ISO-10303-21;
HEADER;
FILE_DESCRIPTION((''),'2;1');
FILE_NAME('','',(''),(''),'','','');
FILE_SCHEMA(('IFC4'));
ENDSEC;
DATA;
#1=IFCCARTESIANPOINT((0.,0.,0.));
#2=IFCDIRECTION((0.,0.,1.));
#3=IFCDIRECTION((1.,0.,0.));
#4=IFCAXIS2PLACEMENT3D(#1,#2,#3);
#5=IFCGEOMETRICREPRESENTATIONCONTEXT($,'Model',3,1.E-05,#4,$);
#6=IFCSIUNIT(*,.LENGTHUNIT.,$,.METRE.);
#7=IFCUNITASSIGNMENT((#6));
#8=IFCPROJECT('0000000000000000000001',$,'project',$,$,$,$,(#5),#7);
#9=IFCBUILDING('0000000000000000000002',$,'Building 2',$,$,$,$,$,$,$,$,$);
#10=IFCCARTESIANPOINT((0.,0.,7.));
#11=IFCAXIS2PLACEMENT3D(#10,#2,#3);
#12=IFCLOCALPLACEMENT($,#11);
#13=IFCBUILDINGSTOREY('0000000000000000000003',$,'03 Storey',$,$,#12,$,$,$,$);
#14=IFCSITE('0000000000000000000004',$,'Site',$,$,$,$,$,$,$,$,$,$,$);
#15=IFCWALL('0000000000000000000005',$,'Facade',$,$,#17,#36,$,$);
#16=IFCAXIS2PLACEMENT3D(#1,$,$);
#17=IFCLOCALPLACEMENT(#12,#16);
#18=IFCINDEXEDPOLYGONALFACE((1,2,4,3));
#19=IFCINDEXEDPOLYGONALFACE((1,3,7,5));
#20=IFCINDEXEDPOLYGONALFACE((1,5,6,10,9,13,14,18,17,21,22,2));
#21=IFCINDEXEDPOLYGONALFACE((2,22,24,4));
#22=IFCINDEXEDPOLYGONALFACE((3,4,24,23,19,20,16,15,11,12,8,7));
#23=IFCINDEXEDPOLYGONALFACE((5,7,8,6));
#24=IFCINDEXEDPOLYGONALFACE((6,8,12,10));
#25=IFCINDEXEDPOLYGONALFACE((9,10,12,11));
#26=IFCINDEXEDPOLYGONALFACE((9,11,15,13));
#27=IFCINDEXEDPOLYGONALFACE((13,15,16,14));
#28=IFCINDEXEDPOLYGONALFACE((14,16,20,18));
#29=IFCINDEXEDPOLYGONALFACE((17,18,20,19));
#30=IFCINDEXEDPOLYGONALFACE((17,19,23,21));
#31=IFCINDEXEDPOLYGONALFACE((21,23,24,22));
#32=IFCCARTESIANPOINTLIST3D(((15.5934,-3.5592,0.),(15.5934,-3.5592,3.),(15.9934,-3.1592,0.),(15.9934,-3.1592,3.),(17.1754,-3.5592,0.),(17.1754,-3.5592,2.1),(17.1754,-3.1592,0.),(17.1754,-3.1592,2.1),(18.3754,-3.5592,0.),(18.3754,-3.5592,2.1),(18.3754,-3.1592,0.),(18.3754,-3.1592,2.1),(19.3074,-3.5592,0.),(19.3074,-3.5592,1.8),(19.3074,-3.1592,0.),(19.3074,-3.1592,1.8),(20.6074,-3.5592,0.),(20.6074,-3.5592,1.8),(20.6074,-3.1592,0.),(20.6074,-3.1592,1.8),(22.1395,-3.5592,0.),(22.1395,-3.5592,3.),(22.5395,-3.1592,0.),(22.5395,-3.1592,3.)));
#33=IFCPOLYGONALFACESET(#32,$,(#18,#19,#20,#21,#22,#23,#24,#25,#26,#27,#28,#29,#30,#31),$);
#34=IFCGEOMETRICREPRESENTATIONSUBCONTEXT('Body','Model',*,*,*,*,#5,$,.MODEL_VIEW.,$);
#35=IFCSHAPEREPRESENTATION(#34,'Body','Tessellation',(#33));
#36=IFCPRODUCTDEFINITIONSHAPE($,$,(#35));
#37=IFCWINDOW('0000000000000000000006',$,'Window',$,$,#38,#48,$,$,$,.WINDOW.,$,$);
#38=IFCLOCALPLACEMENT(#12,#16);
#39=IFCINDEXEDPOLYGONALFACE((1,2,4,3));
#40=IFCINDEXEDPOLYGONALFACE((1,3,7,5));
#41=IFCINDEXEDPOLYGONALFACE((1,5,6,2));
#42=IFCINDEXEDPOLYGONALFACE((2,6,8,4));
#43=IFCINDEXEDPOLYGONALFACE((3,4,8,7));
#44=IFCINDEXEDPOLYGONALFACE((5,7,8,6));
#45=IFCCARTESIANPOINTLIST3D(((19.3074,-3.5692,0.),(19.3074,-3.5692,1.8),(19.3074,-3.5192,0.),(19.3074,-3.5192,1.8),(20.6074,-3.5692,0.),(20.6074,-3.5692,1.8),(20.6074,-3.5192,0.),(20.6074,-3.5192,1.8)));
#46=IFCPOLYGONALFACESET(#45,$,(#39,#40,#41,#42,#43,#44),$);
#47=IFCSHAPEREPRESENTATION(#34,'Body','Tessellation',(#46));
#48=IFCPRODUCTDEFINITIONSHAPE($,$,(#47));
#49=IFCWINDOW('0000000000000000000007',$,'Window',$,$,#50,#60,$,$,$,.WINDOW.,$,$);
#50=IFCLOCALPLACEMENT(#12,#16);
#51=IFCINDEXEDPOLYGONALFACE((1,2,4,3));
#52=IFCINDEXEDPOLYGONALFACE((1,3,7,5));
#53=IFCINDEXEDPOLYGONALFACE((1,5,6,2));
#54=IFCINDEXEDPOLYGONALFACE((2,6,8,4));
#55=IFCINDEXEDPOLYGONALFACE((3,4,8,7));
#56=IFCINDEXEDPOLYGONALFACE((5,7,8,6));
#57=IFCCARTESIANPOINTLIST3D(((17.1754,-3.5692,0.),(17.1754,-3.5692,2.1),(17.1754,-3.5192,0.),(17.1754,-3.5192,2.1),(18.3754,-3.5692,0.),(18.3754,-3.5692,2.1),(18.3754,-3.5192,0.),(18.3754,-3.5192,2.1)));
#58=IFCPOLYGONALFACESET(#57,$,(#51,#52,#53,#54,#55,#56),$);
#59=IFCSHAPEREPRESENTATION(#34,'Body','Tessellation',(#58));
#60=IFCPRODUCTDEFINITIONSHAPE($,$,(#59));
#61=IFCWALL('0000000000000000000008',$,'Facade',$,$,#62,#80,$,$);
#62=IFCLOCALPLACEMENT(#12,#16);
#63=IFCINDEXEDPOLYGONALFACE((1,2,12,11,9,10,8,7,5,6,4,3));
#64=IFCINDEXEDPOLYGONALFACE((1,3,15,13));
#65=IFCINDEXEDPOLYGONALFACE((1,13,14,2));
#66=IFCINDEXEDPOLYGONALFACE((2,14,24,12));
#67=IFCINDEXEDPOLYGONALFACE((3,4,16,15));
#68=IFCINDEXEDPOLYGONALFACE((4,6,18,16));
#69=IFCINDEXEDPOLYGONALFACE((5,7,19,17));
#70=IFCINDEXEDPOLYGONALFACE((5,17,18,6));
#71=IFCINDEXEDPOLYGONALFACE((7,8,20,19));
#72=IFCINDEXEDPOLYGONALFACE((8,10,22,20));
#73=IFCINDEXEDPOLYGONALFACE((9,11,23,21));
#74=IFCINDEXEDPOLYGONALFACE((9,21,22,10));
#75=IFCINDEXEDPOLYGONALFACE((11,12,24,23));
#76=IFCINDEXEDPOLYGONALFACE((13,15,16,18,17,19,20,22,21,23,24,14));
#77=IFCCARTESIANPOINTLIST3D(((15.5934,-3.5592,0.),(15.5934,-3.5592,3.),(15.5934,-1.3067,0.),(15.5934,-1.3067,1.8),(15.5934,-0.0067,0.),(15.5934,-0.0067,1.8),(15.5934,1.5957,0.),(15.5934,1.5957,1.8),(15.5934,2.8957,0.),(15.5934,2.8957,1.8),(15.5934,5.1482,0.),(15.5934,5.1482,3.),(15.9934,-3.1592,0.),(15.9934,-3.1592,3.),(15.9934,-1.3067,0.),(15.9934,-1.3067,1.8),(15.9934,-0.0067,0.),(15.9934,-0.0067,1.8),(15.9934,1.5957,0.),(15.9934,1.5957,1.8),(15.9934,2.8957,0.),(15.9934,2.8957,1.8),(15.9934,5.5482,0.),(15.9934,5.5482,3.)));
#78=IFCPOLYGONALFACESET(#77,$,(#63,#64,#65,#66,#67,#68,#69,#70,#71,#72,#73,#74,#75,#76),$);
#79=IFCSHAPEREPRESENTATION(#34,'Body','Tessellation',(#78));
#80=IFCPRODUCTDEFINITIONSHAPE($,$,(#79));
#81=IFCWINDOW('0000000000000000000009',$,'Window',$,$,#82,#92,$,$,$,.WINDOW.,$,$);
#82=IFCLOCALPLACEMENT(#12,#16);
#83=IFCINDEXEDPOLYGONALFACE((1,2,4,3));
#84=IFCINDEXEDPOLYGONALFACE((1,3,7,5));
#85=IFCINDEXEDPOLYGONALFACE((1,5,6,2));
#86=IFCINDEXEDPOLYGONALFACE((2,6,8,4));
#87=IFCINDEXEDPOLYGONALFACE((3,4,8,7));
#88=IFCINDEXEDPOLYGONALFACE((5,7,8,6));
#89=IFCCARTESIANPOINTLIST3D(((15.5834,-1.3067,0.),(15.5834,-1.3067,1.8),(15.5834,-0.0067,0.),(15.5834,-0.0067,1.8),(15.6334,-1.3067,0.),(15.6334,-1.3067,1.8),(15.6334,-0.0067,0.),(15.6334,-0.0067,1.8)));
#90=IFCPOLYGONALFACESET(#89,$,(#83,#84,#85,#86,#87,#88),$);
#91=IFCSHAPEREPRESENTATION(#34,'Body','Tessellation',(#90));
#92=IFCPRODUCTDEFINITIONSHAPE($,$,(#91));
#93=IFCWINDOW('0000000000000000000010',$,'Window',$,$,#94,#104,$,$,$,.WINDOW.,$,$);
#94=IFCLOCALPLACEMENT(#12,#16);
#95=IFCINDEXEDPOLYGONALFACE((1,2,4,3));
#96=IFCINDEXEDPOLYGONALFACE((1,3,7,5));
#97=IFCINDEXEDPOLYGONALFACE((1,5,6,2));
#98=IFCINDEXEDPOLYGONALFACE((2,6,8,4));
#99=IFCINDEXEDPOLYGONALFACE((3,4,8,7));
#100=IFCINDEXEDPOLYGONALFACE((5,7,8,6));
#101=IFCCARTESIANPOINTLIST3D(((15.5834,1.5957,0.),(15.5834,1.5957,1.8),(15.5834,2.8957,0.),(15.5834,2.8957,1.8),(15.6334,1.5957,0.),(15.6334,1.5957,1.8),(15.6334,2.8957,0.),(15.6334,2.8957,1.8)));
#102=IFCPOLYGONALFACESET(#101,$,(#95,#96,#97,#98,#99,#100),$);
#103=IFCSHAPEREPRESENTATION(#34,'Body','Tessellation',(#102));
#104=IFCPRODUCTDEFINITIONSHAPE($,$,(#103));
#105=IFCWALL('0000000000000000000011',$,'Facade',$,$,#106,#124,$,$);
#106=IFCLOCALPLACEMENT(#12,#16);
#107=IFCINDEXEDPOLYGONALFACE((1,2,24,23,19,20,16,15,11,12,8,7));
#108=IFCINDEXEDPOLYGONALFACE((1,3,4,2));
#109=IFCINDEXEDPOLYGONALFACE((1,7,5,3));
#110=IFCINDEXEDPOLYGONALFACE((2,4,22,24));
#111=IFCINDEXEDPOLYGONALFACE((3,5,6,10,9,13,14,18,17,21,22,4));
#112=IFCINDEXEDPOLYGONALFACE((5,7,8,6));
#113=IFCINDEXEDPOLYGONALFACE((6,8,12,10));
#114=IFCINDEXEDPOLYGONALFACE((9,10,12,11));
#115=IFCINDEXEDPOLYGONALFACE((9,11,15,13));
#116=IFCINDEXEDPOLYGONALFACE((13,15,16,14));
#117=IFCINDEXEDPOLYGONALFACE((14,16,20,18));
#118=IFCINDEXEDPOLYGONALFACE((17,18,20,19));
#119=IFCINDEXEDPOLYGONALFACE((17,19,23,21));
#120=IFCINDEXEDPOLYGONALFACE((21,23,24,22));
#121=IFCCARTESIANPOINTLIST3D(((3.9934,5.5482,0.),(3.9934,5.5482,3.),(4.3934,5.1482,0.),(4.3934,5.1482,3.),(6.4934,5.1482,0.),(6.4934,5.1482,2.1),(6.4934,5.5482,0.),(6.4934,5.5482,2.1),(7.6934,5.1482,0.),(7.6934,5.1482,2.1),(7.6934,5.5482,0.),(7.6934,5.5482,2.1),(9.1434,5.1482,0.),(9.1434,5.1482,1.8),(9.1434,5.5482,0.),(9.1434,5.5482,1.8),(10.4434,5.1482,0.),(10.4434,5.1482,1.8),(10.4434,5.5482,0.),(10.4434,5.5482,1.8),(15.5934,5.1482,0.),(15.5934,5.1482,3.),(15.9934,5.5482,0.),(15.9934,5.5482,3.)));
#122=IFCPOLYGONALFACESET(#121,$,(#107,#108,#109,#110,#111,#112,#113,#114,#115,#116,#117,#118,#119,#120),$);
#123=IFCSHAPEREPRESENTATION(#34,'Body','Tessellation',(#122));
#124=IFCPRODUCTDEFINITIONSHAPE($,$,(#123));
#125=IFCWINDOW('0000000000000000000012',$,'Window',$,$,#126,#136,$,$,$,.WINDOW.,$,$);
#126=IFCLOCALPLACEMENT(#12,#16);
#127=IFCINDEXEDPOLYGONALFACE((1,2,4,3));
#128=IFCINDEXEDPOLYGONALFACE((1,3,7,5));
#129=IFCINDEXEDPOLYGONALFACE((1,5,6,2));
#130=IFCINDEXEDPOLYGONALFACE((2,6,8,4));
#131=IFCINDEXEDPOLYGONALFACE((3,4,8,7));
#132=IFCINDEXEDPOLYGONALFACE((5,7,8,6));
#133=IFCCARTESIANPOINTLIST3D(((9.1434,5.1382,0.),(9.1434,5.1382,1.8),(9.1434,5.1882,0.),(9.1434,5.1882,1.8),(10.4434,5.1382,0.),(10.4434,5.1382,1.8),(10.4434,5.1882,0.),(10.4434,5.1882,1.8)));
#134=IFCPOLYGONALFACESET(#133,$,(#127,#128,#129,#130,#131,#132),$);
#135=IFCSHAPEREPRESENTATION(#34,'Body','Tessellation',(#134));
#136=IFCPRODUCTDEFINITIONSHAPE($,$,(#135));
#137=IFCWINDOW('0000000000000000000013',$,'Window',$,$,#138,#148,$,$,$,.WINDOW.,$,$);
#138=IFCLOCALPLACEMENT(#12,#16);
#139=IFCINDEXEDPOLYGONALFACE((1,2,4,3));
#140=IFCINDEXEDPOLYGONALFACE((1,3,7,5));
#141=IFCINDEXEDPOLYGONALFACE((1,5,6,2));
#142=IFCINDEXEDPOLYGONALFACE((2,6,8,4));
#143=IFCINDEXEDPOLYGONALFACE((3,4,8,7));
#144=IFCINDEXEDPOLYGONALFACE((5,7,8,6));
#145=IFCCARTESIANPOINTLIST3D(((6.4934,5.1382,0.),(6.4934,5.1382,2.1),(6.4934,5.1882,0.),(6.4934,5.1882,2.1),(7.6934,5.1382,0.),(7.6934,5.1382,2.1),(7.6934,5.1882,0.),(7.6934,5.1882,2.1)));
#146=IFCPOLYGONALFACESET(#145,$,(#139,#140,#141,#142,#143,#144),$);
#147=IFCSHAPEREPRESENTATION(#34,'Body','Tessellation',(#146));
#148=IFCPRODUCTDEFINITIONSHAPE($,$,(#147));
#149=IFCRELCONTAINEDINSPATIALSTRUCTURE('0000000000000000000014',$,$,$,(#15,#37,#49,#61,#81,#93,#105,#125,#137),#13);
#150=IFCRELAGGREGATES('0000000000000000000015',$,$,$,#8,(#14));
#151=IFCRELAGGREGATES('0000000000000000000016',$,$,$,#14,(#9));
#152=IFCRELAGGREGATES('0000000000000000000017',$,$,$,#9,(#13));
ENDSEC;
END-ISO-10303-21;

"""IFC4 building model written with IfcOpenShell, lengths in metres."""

from ifc_helpers import new_model, si_unit, frame, origin_with_axes, place, context, subcontext, project, spatial, line, indexed_curve, outline, extrude, element, fill, save


model = new_model("IFC4")

# Units and contexts
model_context = context("Model", 3, precision=1e-05, world=origin_with_axes())
body_context = subcontext(model_context, "Body", "Model", "MODEL_VIEW")
ifc_project = project(units=[si_unit("LENGTHUNIT", "METRE")], contexts=[model_context])

# Site, building, storey
site = spatial("IfcSite", under=ifc_project, Name="Site")
building = spatial("IfcBuilding", under=site, Name="Building 2")
storey_placement = place(None, frame((0.0, 0.0, 7.0), z_axis=(0.0, 0.0, 1.0), x_axis=(1.0, 0.0, 0.0)))
storey = spatial("IfcBuildingStorey", under=building, at=storey_placement, Name="03 Storey")

# Walls, openings, windows
wall_1_placement = place(storey_placement, origin_with_axes())
wall_1 = element("IfcWall", 1, at=wall_1_placement, inside=storey, Name="Facade", context=body_context, shape_type="SweptSolid", body=[
    extrude(outline(indexed_curve([(22.1395, -3.5592), (15.5934, -3.5592), (15.9934, -3.1592), (22.5395, -3.1592)], segments=[line(1, 2), line(2, 3), line(3, 4)])), origin_with_axes(), (0.0, 0.0, 1.0), 3.0),
])
opening_1_placement = place(wall_1_placement, origin_with_axes())
opening_1 = element("IfcOpeningElement", 2, at=opening_1_placement, cuts=wall_1, context=body_context, shape_type="SweptSolid", body=[
    extrude(outline(indexed_curve([(20.6074, -3.1192), (20.6074, -3.6192), (19.3074, -3.6192), (19.3074, -3.1192)], segments=[line(1, 2), line(2, 3), line(3, 4)])), origin_with_axes(), (0.0, 0.0, 1.0), 1.8),
])
opening_2_placement = place(wall_1_placement, origin_with_axes())
opening_2 = element("IfcOpeningElement", 3, at=opening_2_placement, cuts=wall_1, context=body_context, shape_type="SweptSolid", body=[
    extrude(outline(indexed_curve([(18.3754, -3.1192), (18.3754, -3.6192), (17.1754, -3.6192), (17.1754, -3.1192)], segments=[line(1, 2), line(2, 3), line(3, 4)])), origin_with_axes(), (0.0, 0.0, 1.0), 2.1),
])
window_1_placement = place(storey_placement, origin_with_axes())
window_1 = element("IfcWindow", 4, at=window_1_placement, inside=storey, Name="Window", PredefinedType="WINDOW", context=body_context, shape_type="SweptSolid", body=[
    extrude(outline(indexed_curve([(20.6074, -3.5192), (20.6074, -3.5692), (19.3074, -3.5692), (19.3074, -3.5192)], segments=[line(1, 2), line(2, 3), line(3, 4)])), origin_with_axes(), (0.0, 0.0, 1.0), 1.8),
])
fill(opening_1, window_1)
window_2_placement = place(storey_placement, origin_with_axes())
window_2 = element("IfcWindow", 5, at=window_2_placement, inside=storey, Name="Window", PredefinedType="WINDOW", context=body_context, shape_type="SweptSolid", body=[
    extrude(outline(indexed_curve([(18.3754, -3.5192), (18.3754, -3.5692), (17.1754, -3.5692), (17.1754, -3.5192)], segments=[line(1, 2), line(2, 3), line(3, 4)])), origin_with_axes(), (0.0, 0.0, 1.0), 2.1),
])
fill(opening_2, window_2)
wall_2_placement = place(storey_placement, origin_with_axes())
wall_2 = element("IfcWall", 6, at=wall_2_placement, inside=storey, Name="Facade", context=body_context, shape_type="SweptSolid", body=[
    extrude(outline(indexed_curve([(15.5934, -3.5592), (15.5934, 5.1482), (15.9934, 5.5482), (15.9934, -3.1592)], segments=[line(1, 2), line(2, 3), line(3, 4)])), origin_with_axes(), (0.0, 0.0, 1.0), 3.0),
])
opening_3_placement = place(wall_2_placement, origin_with_axes())
opening_3 = element("IfcOpeningElement", 7, at=opening_3_placement, cuts=wall_2, context=body_context, shape_type="SweptSolid", body=[
    extrude(outline(indexed_curve([(16.0334, -1.3067), (15.5334, -1.3067), (15.5334, -0.0067), (16.0334, -0.0067)], segments=[line(1, 2), line(2, 3), line(3, 4)])), origin_with_axes(), (0.0, 0.0, 1.0), 1.8),
])
opening_4_placement = place(wall_2_placement, origin_with_axes())
opening_4 = element("IfcOpeningElement", 8, at=opening_4_placement, cuts=wall_2, context=body_context, shape_type="SweptSolid", body=[
    extrude(outline(indexed_curve([(16.0334, 1.5957), (15.5334, 1.5957), (15.5334, 2.8957), (16.0334, 2.8957)], segments=[line(1, 2), line(2, 3), line(3, 4)])), origin_with_axes(), (0.0, 0.0, 1.0), 1.8),
])
window_3_placement = place(storey_placement, origin_with_axes())
window_3 = element("IfcWindow", 9, at=window_3_placement, inside=storey, Name="Window", PredefinedType="WINDOW", context=body_context, shape_type="SweptSolid", body=[
    extrude(outline(indexed_curve([(15.6334, -1.3067), (15.5834, -1.3067), (15.5834, -0.0067), (15.6334, -0.0067)], segments=[line(1, 2), line(2, 3), line(3, 4)])), origin_with_axes(), (0.0, 0.0, 1.0), 1.8),
])
fill(opening_3, window_3)
window_4_placement = place(storey_placement, origin_with_axes())
window_4 = element("IfcWindow", 10, at=window_4_placement, inside=storey, Name="Window", PredefinedType="WINDOW", context=body_context, shape_type="SweptSolid", body=[
    extrude(outline(indexed_curve([(15.6334, 1.5957), (15.5834, 1.5957), (15.5834, 2.8957), (15.6334, 2.8957)], segments=[line(1, 2), line(2, 3), line(3, 4)])), origin_with_axes(), (0.0, 0.0, 1.0), 1.8),
])
fill(opening_4, window_4)
wall_3_placement = place(storey_placement, origin_with_axes())
wall_3 = element("IfcWall", 11, at=wall_3_placement, inside=storey, Name="Facade", context=body_context, shape_type="SweptSolid", body=[
    extrude(outline(indexed_curve([(15.5934, 5.1482), (4.3934, 5.1482), (3.9934, 5.5482), (15.9934, 5.5482)], segments=[line(1, 2), line(2, 3), line(3, 4)])), origin_with_axes(), (0.0, 0.0, 1.0), 3.0),
])
opening_5_placement = place(wall_3_placement, origin_with_axes())
opening_5 = element("IfcOpeningElement", 12, at=opening_5_placement, cuts=wall_3, context=body_context, shape_type="SweptSolid", body=[
    extrude(outline(indexed_curve([(10.4434, 5.5882), (10.4434, 5.0882), (9.1434, 5.0882), (9.1434, 5.5882)], segments=[line(1, 2), line(2, 3), line(3, 4)])), origin_with_axes(), (0.0, 0.0, 1.0), 1.8),
])
opening_6_placement = place(wall_3_placement, origin_with_axes())
opening_6 = element("IfcOpeningElement", 13, at=opening_6_placement, cuts=wall_3, context=body_context, shape_type="SweptSolid", body=[
    extrude(outline(indexed_curve([(7.6934, 5.5882), (7.6934, 5.0882), (6.4934, 5.0882), (6.4934, 5.5882)], segments=[line(1, 2), line(2, 3), line(3, 4)])), origin_with_axes(), (0.0, 0.0, 1.0), 2.1),
])
window_5_placement = place(storey_placement, origin_with_axes())
window_5 = element("IfcWindow", 14, at=window_5_placement, inside=storey, Name="Window", PredefinedType="WINDOW", context=body_context, shape_type="SweptSolid", body=[
    extrude(outline(indexed_curve([(10.4434, 5.1882), (10.4434, 5.1382), (9.1434, 5.1382), (9.1434, 5.1882)], segments=[line(1, 2), line(2, 3), line(3, 4)])), origin_with_axes(), (0.0, 0.0, 1.0), 1.8),
])
fill(opening_5, window_5)
window_6_placement = place(storey_placement, origin_with_axes())
window_6 = element("IfcWindow", 15, at=window_6_placement, inside=storey, Name="Window", PredefinedType="WINDOW", context=body_context, shape_type="SweptSolid", body=[
    extrude(outline(indexed_curve([(7.6934, 5.1882), (7.6934, 5.1382), (6.4934, 5.1382), (6.4934, 5.1882)], segments=[line(1, 2), line(2, 3), line(3, 4)])), origin_with_axes(), (0.0, 0.0, 1.0), 2.1),
])
fill(opening_6, window_6)

save(model, "model.ifc")
